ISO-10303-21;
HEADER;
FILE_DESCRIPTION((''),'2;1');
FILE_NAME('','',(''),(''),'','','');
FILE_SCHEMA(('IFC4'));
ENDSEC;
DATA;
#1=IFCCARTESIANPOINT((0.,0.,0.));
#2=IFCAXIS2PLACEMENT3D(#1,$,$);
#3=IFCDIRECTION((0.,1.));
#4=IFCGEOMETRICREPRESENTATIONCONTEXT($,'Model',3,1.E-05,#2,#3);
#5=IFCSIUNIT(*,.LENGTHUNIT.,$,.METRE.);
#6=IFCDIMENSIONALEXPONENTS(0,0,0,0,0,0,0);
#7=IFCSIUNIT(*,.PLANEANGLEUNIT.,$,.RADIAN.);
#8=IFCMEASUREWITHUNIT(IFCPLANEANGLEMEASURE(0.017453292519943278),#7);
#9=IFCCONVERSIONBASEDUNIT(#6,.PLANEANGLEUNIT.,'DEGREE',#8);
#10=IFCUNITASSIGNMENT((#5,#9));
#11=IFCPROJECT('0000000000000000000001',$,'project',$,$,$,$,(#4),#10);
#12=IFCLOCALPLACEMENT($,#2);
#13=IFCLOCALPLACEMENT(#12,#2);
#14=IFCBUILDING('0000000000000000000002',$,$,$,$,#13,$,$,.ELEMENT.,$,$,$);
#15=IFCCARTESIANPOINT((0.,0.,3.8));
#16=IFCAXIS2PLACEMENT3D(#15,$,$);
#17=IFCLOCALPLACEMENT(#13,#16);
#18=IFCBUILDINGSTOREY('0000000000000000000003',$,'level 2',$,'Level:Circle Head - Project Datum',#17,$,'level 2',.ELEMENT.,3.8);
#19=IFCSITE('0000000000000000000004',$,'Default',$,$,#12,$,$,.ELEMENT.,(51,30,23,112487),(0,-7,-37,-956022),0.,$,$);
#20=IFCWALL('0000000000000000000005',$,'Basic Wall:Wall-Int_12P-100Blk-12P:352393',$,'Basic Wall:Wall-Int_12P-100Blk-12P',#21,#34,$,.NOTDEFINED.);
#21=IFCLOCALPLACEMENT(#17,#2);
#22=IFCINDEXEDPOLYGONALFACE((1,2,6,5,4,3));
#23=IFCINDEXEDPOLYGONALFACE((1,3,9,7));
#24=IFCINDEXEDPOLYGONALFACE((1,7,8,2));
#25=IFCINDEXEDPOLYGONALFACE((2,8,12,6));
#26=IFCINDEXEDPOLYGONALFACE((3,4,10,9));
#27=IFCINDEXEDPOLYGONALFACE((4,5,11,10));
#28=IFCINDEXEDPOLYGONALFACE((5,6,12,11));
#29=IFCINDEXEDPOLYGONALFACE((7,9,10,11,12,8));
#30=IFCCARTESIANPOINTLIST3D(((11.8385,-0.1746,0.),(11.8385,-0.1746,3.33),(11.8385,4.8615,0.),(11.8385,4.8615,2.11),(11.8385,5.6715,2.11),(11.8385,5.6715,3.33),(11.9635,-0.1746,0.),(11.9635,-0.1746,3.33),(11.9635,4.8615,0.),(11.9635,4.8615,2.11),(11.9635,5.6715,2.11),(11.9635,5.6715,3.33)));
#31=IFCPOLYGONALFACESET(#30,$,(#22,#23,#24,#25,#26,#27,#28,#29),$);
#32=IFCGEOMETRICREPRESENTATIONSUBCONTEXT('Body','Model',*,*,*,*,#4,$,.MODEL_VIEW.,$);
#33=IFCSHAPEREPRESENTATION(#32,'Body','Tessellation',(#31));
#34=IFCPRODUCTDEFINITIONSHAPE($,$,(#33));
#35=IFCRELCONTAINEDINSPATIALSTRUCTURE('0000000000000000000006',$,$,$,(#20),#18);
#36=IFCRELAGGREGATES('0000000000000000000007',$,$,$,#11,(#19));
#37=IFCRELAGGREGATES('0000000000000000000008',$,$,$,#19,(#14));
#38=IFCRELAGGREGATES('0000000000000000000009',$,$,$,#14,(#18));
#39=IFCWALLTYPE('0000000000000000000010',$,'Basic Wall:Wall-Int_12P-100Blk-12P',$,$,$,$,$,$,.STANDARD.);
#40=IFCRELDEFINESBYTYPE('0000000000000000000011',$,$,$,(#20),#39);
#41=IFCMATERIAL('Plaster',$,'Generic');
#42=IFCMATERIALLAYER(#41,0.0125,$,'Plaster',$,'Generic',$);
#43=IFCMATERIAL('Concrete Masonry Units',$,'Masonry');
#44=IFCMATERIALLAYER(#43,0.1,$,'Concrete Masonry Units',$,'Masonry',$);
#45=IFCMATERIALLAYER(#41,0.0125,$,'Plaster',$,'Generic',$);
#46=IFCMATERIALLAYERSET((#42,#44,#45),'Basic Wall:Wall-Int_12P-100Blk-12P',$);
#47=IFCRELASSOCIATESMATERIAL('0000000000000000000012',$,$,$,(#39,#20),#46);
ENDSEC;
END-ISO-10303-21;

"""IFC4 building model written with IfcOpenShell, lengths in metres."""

from ifc_helpers import new_model, entity, si_unit, converted_unit, direction, frame, frame_2d, origin, place, context, subcontext, project, spatial, polyline, rectangle, extrude, clip, bounded_halfspace, material, layer, layer_set, layer_usage, type_object, element, save


model = new_model("IFC4")

# Units and contexts
model_context = context("Model", 3, precision=1e-05, world=origin(), true_north=direction((0.0, 1.0)))
body_context = subcontext(model_context, "Body", "Model", "MODEL_VIEW")
ifc_project = project(units=[si_unit("LENGTHUNIT", "METRE"), converted_unit("PLANEANGLEUNIT", "DEGREE", entity("IfcPlaneAngleMeasure", 0.017453292519943278), si_unit("PLANEANGLEUNIT", "RADIAN"), dimensions=[0, 0, 0, 0, 0, 0, 0])], contexts=[model_context])

# Site, building, storey
site_placement = place(None, origin())
site = spatial("IfcSite", under=ifc_project, at=site_placement, Name="Default", CompositionType="ELEMENT", RefLatitude=(51, 30, 23, 112487), RefLongitude=(0, -7, -37, -956022), RefElevation=0.0)
building_placement = place(site_placement, origin())
building = spatial("IfcBuilding", under=site, at=building_placement, CompositionType="ELEMENT")
storey_placement = place(building_placement, frame((0.0, 0.0, 3.8)))
storey = spatial("IfcBuildingStorey", under=building, at=storey_placement, Name="level 2", ObjectType="Level:Circle Head - Project Datum", LongName="level 2", CompositionType="ELEMENT", Elevation=3.8)

# Wall, opening
ifc_material_1 = material(Name="Plaster", Category="Generic")
ifc_layer_1 = layer(ifc_material_1, 0.0125, Name="Plaster", Category="Generic")
ifc_material_2 = material(Name="Concrete Masonry Units", Category="Masonry")
ifc_layer_2 = layer(ifc_material_2, 0.1, Name="Concrete Masonry Units", Category="Masonry")
ifc_layer_3 = layer(ifc_material_1, 0.0125, Name="Plaster", Category="Generic")
ifc_layer_set = layer_set([ifc_layer_1, ifc_layer_2, ifc_layer_3], Name="Basic Wall:Wall-Int_12P-100Blk-12P")
wall_type = type_object("IfcWallType", Name="Basic Wall:Wall-Int_12P-100Blk-12P", PredefinedType="STANDARD", material=ifc_layer_set)
ifc_layer_usage_1 = layer_usage(ifc_layer_set, "AXIS2", "NEGATIVE", 0.0625)
wall_1_placement = place(storey_placement, frame((11.901, 5.6715, 0.0), z_axis=(0.0, 0.0, 1.0), x_axis=(0.0, -1.0, 0.0)))
wall_1 = element("IfcWall", 1, at=wall_1_placement, inside=storey, type_object=wall_type, material=ifc_layer_usage_1, Name="Basic Wall:Wall-Int_12P-100Blk-12P:352393", ObjectType="Basic Wall:Wall-Int_12P-100Blk-12P", PredefinedType="NOTDEFINED", context=body_context, shape_type="Clipping", body=[
    clip(extrude(rectangle(XDim=5.846, YDim=0.125, at=frame_2d((2.923, 0.0), x_axis=(-1.0, 0.0))), origin(), (0.0, 0.0, 1.0), 3.33), bounded_halfspace(frame((0.0, -0.0625, 3.33), z_axis=(0.0, 0.0, -1.0), x_axis=(-1.0, 0.0, 0.0)), True, frame((0.0, -0.0625, 3.33)), polyline([(0.0, 0.0), (5.846, 0.0), (5.846, 0.125), (0.0, 0.125), (0.0, 0.0)]))),
])
opening_1_placement = place(wall_1_placement, frame((0.0, -0.0625, 0.0)))
element("IfcOpeningElement", 2, at=opening_1_placement, cuts=wall_1, PredefinedType="OPENING", context=body_context, shape_type="SweptSolid", body=[
    extrude(rectangle(XDim=2.11, YDim=0.81, at=frame_2d((1.055, 0.405), x_axis=(1.0, 0.0))), frame((0.0, 0.0, 0.0), z_axis=(0.0, 1.0, 0.0), x_axis=(0.0, 0.0, 1.0)), (0.0, 0.0, 1.0), 0.125),
])

save(model, "model.ifc")
